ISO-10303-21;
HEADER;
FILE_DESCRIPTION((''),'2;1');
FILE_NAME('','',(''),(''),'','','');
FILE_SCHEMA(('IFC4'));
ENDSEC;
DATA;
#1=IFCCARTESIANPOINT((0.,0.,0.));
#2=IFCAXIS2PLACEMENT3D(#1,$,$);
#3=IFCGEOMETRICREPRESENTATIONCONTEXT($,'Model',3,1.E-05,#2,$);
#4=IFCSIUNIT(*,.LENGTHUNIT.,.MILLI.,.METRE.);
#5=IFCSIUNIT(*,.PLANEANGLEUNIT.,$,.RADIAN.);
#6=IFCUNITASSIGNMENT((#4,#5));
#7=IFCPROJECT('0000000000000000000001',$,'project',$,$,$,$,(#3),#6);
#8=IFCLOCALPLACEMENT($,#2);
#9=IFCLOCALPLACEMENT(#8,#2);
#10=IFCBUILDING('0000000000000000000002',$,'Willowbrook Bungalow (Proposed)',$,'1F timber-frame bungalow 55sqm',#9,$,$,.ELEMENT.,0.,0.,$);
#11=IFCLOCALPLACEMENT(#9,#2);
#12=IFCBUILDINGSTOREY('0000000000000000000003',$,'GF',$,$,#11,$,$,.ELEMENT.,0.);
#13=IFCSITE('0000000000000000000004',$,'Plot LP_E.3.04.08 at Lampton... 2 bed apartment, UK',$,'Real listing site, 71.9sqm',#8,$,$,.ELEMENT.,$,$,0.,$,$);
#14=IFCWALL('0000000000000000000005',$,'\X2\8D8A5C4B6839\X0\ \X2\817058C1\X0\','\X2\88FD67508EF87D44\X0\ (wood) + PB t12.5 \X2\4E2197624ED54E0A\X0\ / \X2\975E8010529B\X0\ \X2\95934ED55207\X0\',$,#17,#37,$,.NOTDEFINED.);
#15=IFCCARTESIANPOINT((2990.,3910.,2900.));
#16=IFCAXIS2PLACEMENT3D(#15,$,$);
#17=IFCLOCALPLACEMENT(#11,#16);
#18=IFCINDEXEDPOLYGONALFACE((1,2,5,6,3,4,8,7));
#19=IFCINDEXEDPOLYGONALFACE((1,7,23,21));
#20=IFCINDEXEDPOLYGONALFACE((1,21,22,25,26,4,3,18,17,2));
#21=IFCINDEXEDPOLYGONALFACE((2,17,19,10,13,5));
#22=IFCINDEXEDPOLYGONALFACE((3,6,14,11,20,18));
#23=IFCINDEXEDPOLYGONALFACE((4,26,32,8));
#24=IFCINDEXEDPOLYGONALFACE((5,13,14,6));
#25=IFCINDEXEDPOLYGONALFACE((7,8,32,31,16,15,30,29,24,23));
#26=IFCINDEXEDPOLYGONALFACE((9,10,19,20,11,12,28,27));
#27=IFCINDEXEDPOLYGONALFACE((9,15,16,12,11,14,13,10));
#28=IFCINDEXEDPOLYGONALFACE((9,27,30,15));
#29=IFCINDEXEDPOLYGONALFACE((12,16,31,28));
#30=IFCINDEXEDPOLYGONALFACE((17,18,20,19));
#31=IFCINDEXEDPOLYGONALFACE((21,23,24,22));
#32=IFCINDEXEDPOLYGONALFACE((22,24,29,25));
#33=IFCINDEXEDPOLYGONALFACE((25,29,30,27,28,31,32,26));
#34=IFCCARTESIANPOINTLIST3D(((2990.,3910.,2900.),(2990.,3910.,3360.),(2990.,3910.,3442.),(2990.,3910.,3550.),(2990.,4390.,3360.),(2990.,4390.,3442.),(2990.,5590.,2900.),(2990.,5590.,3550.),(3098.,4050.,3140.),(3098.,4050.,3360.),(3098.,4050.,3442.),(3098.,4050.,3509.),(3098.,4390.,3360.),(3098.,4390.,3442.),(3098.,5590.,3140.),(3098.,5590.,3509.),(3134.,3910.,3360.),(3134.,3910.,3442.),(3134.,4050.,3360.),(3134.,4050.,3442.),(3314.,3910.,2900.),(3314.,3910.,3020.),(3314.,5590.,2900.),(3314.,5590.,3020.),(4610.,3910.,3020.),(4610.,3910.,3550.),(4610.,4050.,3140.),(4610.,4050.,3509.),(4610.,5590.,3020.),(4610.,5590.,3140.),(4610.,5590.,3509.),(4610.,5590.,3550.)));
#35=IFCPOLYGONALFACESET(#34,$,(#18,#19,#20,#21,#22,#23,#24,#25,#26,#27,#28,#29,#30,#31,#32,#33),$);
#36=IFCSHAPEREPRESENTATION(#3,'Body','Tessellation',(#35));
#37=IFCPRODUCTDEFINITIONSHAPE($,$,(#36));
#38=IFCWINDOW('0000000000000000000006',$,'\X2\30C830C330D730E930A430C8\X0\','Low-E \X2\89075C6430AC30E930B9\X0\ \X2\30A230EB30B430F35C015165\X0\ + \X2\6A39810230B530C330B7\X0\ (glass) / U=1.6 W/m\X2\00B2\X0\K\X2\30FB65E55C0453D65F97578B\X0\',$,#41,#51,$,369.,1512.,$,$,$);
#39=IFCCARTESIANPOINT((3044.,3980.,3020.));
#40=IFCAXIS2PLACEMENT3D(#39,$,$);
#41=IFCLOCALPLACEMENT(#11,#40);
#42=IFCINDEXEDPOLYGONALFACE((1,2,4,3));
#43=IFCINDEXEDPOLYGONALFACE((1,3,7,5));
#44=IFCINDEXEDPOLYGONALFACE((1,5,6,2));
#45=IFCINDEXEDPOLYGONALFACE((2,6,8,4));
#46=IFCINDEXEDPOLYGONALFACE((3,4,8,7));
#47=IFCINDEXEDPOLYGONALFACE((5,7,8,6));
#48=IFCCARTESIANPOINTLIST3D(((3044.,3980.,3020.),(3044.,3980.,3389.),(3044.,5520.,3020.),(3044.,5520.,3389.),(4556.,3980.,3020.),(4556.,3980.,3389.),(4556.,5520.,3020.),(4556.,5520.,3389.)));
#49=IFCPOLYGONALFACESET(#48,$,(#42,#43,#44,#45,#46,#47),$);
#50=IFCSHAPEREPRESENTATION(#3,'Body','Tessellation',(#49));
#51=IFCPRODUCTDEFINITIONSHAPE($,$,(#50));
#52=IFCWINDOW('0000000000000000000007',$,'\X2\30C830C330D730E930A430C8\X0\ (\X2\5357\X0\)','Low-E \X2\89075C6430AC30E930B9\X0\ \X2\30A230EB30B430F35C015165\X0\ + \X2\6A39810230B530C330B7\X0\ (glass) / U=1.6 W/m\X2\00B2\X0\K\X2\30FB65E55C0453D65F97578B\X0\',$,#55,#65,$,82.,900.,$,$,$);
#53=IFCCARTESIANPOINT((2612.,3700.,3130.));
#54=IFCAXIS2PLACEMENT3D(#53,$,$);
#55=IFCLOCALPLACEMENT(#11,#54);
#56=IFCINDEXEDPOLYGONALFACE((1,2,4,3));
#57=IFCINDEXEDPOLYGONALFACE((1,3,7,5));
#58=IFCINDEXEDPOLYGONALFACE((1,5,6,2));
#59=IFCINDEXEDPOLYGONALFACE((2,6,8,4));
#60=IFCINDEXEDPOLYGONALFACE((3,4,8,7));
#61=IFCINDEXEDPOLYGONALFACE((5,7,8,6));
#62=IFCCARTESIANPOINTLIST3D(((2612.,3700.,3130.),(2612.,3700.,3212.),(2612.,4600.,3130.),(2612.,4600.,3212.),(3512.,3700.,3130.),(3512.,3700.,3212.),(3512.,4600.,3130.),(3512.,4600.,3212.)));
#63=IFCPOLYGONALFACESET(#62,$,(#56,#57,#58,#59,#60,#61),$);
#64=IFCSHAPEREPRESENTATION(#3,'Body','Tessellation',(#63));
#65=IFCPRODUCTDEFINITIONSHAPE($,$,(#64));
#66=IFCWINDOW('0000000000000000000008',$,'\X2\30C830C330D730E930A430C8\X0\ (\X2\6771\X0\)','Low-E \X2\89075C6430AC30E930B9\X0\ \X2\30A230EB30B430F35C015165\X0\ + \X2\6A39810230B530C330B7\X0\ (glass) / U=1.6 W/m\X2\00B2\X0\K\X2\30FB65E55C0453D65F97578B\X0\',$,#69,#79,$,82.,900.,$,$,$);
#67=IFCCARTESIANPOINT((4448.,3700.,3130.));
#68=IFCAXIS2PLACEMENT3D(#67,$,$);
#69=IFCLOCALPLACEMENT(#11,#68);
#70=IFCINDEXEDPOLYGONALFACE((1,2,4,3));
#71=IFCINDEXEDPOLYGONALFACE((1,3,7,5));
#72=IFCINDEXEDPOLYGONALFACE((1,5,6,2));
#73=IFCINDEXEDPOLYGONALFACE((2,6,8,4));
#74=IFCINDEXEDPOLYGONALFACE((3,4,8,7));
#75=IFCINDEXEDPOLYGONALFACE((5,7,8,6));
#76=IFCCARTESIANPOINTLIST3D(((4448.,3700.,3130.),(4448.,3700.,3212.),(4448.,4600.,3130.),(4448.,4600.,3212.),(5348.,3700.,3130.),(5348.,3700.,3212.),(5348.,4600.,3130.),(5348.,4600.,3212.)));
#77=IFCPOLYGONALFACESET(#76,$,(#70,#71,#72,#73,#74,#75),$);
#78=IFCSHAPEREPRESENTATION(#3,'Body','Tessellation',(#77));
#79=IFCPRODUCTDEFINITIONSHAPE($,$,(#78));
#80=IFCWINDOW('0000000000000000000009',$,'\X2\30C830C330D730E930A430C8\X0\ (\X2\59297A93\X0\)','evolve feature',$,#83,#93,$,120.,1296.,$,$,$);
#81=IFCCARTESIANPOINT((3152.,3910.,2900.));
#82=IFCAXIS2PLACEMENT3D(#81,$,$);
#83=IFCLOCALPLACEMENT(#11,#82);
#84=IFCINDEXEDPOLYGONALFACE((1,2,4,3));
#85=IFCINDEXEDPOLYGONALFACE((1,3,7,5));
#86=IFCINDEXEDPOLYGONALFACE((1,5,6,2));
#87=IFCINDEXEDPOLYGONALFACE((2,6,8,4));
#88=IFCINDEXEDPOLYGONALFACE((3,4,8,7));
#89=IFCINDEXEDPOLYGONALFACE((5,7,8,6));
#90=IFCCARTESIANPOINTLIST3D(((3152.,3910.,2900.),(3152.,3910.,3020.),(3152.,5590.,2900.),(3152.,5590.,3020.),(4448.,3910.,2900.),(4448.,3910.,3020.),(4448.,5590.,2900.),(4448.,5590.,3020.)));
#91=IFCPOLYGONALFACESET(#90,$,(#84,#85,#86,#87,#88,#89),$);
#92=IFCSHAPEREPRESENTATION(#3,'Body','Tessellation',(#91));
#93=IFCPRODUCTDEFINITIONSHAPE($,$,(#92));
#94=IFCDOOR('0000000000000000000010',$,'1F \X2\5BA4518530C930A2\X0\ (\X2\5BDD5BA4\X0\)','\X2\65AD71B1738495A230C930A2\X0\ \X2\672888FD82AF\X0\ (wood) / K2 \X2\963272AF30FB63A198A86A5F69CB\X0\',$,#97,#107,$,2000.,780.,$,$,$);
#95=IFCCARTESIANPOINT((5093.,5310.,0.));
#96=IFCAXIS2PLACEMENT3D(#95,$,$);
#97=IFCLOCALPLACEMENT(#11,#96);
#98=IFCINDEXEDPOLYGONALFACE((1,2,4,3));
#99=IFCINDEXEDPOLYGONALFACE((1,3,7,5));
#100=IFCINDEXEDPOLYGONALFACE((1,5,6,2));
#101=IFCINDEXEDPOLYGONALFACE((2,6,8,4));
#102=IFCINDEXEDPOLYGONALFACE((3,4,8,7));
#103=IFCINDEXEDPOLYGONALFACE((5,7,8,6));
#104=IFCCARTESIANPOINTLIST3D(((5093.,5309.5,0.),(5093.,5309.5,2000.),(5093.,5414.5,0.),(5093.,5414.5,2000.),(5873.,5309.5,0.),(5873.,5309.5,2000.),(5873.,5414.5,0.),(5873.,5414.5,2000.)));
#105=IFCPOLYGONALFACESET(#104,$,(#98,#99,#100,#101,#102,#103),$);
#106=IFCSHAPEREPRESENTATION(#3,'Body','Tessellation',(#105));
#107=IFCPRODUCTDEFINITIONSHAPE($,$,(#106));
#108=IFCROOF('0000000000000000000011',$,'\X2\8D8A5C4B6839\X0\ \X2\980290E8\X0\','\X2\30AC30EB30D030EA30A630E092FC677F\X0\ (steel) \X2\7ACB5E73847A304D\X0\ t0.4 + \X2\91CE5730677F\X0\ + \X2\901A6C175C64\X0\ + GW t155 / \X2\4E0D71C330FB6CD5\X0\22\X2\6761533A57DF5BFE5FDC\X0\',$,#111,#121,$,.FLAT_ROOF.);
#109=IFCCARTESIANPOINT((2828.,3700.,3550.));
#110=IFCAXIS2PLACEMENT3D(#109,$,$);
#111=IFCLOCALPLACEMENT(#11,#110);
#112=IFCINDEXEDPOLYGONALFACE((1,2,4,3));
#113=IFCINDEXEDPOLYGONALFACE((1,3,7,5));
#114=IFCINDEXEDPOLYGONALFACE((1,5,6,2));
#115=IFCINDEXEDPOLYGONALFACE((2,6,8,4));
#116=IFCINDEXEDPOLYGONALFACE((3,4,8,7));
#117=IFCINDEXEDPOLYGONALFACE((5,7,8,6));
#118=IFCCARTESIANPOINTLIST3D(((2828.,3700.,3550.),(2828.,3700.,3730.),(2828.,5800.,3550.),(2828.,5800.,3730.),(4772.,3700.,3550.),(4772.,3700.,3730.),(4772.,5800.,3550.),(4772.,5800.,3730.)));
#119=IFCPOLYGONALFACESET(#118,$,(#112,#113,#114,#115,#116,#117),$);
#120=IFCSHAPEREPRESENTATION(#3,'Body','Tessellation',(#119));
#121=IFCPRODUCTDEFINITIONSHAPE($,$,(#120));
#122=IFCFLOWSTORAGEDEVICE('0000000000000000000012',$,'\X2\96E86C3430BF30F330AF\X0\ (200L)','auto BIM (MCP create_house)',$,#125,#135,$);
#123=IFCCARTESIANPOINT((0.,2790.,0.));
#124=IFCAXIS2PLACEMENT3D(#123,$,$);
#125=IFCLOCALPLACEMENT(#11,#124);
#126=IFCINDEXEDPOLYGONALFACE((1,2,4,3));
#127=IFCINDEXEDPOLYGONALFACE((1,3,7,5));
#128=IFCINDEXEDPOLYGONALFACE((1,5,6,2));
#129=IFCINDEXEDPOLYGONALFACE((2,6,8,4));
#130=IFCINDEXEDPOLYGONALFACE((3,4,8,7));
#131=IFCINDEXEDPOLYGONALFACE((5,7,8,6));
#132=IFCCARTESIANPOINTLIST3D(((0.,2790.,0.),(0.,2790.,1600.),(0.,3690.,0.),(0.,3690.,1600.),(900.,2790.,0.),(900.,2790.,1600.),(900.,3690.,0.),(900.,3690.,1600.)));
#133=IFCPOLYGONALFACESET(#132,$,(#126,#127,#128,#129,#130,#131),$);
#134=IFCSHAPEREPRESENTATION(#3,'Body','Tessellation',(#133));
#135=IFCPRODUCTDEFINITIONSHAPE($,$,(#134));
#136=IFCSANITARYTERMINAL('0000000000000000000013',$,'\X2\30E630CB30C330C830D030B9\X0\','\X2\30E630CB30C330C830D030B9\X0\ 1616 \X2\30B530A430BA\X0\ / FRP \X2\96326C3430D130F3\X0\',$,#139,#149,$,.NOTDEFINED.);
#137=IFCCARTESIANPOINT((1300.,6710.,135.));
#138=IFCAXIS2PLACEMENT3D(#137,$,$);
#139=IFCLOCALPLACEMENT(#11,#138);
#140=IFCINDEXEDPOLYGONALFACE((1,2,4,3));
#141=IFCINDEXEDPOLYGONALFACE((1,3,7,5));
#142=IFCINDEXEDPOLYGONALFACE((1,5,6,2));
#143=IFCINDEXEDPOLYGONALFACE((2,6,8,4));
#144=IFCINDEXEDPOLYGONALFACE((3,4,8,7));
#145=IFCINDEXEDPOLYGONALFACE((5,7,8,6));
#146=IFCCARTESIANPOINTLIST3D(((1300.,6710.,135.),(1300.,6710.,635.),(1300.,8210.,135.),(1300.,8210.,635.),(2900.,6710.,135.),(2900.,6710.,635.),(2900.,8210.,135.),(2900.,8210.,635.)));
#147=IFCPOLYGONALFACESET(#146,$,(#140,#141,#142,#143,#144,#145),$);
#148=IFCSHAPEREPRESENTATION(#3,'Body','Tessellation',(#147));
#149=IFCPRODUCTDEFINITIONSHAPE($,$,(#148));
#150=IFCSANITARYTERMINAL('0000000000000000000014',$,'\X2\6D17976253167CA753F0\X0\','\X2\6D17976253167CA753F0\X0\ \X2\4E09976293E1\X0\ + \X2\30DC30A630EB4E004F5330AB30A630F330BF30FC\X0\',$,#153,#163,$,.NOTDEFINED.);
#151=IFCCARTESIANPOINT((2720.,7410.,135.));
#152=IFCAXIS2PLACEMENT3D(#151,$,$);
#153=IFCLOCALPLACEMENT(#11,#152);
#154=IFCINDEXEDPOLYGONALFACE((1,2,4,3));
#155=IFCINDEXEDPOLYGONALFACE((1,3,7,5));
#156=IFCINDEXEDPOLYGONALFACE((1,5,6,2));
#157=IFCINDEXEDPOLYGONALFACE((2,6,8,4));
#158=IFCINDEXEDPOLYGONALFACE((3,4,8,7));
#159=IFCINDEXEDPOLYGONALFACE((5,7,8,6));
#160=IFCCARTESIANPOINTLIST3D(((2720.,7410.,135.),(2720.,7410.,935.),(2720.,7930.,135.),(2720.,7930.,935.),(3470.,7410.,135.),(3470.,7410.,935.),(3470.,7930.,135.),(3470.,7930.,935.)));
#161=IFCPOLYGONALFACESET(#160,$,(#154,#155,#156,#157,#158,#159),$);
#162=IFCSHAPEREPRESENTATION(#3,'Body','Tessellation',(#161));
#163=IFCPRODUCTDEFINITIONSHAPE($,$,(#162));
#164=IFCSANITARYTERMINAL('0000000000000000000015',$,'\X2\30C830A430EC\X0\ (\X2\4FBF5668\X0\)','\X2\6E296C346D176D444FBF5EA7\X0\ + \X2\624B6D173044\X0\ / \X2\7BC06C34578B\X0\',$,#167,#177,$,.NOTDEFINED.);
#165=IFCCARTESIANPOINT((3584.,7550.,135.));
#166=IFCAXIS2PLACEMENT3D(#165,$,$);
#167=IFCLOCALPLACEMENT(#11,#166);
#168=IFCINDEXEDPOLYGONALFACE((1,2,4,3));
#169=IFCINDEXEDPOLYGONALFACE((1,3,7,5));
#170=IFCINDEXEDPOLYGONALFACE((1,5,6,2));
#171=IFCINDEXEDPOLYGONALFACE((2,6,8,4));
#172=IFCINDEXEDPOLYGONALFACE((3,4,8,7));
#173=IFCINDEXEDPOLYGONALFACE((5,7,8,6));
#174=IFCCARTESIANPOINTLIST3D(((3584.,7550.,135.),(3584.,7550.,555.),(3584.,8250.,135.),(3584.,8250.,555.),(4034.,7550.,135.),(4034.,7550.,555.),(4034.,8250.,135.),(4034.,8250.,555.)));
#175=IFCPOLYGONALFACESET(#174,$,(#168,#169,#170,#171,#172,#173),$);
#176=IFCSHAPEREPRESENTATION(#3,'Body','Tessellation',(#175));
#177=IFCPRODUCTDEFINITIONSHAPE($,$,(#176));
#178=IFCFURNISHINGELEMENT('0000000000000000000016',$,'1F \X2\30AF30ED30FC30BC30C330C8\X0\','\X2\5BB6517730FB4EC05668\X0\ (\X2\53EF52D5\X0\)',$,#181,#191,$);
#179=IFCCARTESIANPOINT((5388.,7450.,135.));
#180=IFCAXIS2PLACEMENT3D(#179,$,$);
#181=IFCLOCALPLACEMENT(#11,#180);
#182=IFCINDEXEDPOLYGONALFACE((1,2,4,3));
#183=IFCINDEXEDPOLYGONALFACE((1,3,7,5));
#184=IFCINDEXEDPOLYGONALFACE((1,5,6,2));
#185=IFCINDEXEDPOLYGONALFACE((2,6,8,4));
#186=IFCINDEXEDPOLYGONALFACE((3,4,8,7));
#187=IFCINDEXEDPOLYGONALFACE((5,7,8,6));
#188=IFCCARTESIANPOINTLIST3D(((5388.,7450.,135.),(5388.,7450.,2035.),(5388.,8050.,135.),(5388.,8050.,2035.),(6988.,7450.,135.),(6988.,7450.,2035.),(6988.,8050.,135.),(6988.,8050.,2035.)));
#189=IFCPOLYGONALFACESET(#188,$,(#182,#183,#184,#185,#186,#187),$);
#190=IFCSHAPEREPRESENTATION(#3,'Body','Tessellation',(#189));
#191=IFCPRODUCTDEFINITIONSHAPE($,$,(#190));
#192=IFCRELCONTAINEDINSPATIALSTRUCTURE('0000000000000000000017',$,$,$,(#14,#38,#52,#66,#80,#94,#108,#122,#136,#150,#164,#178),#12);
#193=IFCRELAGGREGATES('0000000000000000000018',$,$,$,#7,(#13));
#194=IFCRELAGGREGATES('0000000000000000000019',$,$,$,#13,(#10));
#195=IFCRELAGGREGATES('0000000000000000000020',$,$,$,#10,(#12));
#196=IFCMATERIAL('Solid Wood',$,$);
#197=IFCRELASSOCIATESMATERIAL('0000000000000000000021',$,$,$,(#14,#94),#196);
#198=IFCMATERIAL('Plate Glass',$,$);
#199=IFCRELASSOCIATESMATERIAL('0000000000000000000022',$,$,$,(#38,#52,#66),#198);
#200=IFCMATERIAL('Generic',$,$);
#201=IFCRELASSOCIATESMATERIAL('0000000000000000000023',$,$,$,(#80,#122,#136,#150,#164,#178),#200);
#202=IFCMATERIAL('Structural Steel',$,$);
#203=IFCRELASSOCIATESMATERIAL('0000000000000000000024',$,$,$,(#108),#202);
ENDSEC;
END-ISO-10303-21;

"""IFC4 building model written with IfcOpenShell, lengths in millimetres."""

from ifc_helpers import new_model, si_unit, frame, frame_2d, origin, place, context, project, spatial, rectangle, extrude, material, element, fill, save


model = new_model("IFC4")

# Units and contexts
model_context = context("Model", 3, precision=1e-05, world=origin())
ifc_project = project(units=[si_unit("LENGTHUNIT", "METRE", prefix="MILLI"), si_unit("PLANEANGLEUNIT", "RADIAN")], contexts=[model_context])

# Site, building, storey
site_placement = place(None, origin())
site = spatial("IfcSite", under=ifc_project, at=site_placement, Name="Plot LP_E.3.04.08 at Lampton... 2 bed apartment, UK", ObjectType="Real listing site, 71.9sqm", CompositionType="ELEMENT", RefElevation=0.0)
building_placement = place(site_placement, origin())
building = spatial("IfcBuilding", under=site, at=building_placement, Name="Willowbrook Bungalow (Proposed)", ObjectType="1F timber-frame bungalow 55sqm", CompositionType="ELEMENT", ElevationOfRefHeight=0.0, ElevationOfTerrain=0.0)
storey_placement = place(building_placement, origin())
storey = spatial("IfcBuildingStorey", under=building, at=storey_placement, Name="GF", CompositionType="ELEMENT", Elevation=0.0)

# Shared definitions
ifc_material_1 = material(Name="Solid Wood")

# Shared definitions
ifc_material_2 = material(Name="Plate Glass")

# Wall, openings, windows
wall_1_placement = place(storey_placement, frame((2990.0, 3910.0, 2900.0)))
wall_1 = element("IfcWall", 1, at=wall_1_placement, inside=storey, material=ifc_material_1, Name="越屋根 腰壁", Description="製材軸組 (wood) + PB t12.5 両面仕上 / 非耐力 間仕切", PredefinedType="NOTDEFINED", context=model_context, shape_type="SweptSolid", body=[
    extrude(rectangle(XDim=1620.0, YDim=1680.0, at=frame_2d((810.0, 840.0))), frame((2990.0, 3910.0, 2900.0)), (0.0, 0.0, 1.0), 650.0),
])
opening_1_placement = place(storey_placement, frame((3044.0, 3980.0, 3020.0)))
opening_1 = element("IfcOpeningElement", 2, at=opening_1_placement, cuts=wall_1, PredefinedType="NOTDEFINED", context=model_context, shape_type="SweptSolid", body=[
    extrude(rectangle(XDim=1512.0, YDim=1540.0, at=frame_2d((756.0, 770.0))), frame((3044.0, 3980.0, 3020.0)), (0.0, 0.0, 1.0), 369.0),
])
opening_2_placement = place(storey_placement, frame((2612.0, 3700.0, 3130.0)))
opening_2 = element("IfcOpeningElement", 3, at=opening_2_placement, cuts=wall_1, PredefinedType="NOTDEFINED", context=model_context, shape_type="SweptSolid", body=[
    extrude(rectangle(XDim=900.0, YDim=900.0, at=frame_2d((450.0, 450.0))), frame((2612.0, 3700.0, 3130.0)), (0.0, 0.0, 1.0), 82.0),
])
opening_3_placement = place(storey_placement, frame((4448.0, 3700.0, 3130.0)))
opening_3 = element("IfcOpeningElement", 4, at=opening_3_placement, cuts=wall_1, PredefinedType="NOTDEFINED", context=model_context, shape_type="SweptSolid", body=[
    extrude(rectangle(XDim=900.0, YDim=900.0, at=frame_2d((450.0, 450.0))), frame((4448.0, 3700.0, 3130.0)), (0.0, 0.0, 1.0), 82.0),
])
opening_4_placement = place(storey_placement, frame((3152.0, 3910.0, 2900.0)))
opening_4 = element("IfcOpeningElement", 5, at=opening_4_placement, cuts=wall_1, PredefinedType="NOTDEFINED", context=model_context, shape_type="SweptSolid", body=[
    extrude(rectangle(XDim=1296.0, YDim=1680.0, at=frame_2d((648.0, 840.0))), frame((3152.0, 3910.0, 2900.0)), (0.0, 0.0, 1.0), 120.0),
])
window_1_placement = place(storey_placement, frame((3044.0, 3980.0, 3020.0)))
window_1 = element("IfcWindow", 6, at=window_1_placement, inside=storey, material=ifc_material_2, Name="トップライト", Description="Low-E 複層ガラス アルゴン封入 + 樹脂サッシ (glass) / U=1.6 W/m²K・日射取得型", OverallHeight=369.0, OverallWidth=1512.0, context=model_context, shape_type="SweptSolid", body=[
    extrude(rectangle(XDim=1512.0, YDim=1540.0, at=frame_2d((756.0, 770.0))), frame((3044.0, 3980.0, 3020.0)), (0.0, 0.0, 1.0), 369.0),
])
fill(opening_1, window_1)
window_2_placement = place(storey_placement, frame((2612.0, 3700.0, 3130.0)))
window_2 = element("IfcWindow", 7, at=window_2_placement, inside=storey, material=ifc_material_2, Name="トップライト (南)", Description="Low-E 複層ガラス アルゴン封入 + 樹脂サッシ (glass) / U=1.6 W/m²K・日射取得型", OverallHeight=82.0, OverallWidth=900.0, context=model_context, shape_type="SweptSolid", body=[
    extrude(rectangle(XDim=900.0, YDim=900.0, at=frame_2d((450.0, 450.0))), frame((2612.0, 3700.0, 3130.0)), (0.0, 0.0, 1.0), 82.0),
])
fill(opening_2, window_2)
window_3_placement = place(storey_placement, frame((4448.0, 3700.0, 3130.0)))
window_3 = element("IfcWindow", 8, at=window_3_placement, inside=storey, material=ifc_material_2, Name="トップライト (東)", Description="Low-E 複層ガラス アルゴン封入 + 樹脂サッシ (glass) / U=1.6 W/m²K・日射取得型", OverallHeight=82.0, OverallWidth=900.0, context=model_context, shape_type="SweptSolid", body=[
    extrude(rectangle(XDim=900.0, YDim=900.0, at=frame_2d((450.0, 450.0))), frame((4448.0, 3700.0, 3130.0)), (0.0, 0.0, 1.0), 82.0),
])
fill(opening_3, window_3)
ifc_material_3 = material(Name="Generic")
window_4_placement = place(storey_placement, frame((3152.0, 3910.0, 2900.0)))
window_4 = element("IfcWindow", 9, at=window_4_placement, inside=storey, material=ifc_material_3, Name="トップライト (天窓)", Description="evolve feature", OverallHeight=120.0, OverallWidth=1296.0, context=model_context, shape_type="SweptSolid", body=[
    extrude(rectangle(XDim=1296.0, YDim=1680.0, at=frame_2d((648.0, 840.0))), frame((3152.0, 3910.0, 2900.0)), (0.0, 0.0, 1.0), 120.0),
])
fill(opening_4, window_4)

# Door
door_1_placement = place(storey_placement, frame((5093.0, 5310.0, 0.0)))
element("IfcDoor", 10, at=door_1_placement, inside=storey, material=ifc_material_1, Name="1F 室内ドア (寝室)", Description="断熱玄関ドア 木製芯 (wood) / K2 防犯・採風機構", OverallHeight=2000.0, OverallWidth=780.0, context=model_context, shape_type="SweptSolid", body=[
    extrude(rectangle(XDim=780.0, YDim=105.0, at=frame_2d((390.0, 52.0))), frame((5093.0, 5310.0, 0.0)), (0.0, 0.0, 1.0), 2000.0),
])

# Roof
ifc_material_4 = material(Name="Structural Steel")
roof_placement = place(storey_placement, frame((2828.0, 3700.0, 3550.0)))
element("IfcRoof", 11, at=roof_placement, inside=storey, material=ifc_material_4, Name="越屋根 頂部", Description="ガルバリウム鋼板 (steel) 立平葺き t0.4 + 野地板 + 通気層 + GW t155 / 不燃・法22条区域対応", PredefinedType="FLAT_ROOF", context=model_context, shape_type="SweptSolid", body=[
    extrude(rectangle(XDim=1944.0, YDim=2100.0, at=frame_2d((972.0, 1050.0))), frame((2828.0, 3700.0, 3550.0)), (0.0, 0.0, 1.0), 180.0),
])

# Flow storage device
flow_storage_device_placement = place(storey_placement, frame((0.0, 2790.0, 0.0)))
element("IfcFlowStorageDevice", 12, at=flow_storage_device_placement, inside=storey, material=ifc_material_3, Name="雨水タンク (200L)", Description="auto BIM (MCP create_house)", context=model_context, shape_type="SweptSolid", body=[
    extrude(rectangle(XDim=900.0, YDim=900.0, at=frame_2d((450.0, 450.0))), frame((0.0, 2790.0, 0.0)), (0.0, 0.0, 1.0), 1600.0),
])

# Sanitary terminals
sanitary_terminal_1_placement = place(storey_placement, frame((1300.0, 6710.0, 135.0)))
element("IfcSanitaryTerminal", 13, at=sanitary_terminal_1_placement, inside=storey, material=ifc_material_3, Name="ユニットバス", Description="ユニットバス 1616 サイズ / FRP 防水パン", PredefinedType="NOTDEFINED", context=model_context, shape_type="SweptSolid", body=[
    extrude(rectangle(XDim=1600.0, YDim=1500.0, at=frame_2d((800.0, 750.0))), frame((1300.0, 6710.0, 135.0)), (0.0, 0.0, 1.0), 500.0),
])
sanitary_terminal_2_placement = place(storey_placement, frame((2720.0, 7410.0, 135.0)))
element("IfcSanitaryTerminal", 14, at=sanitary_terminal_2_placement, inside=storey, material=ifc_material_3, Name="洗面化粧台", Description="洗面化粧台 三面鏡 + ボウル一体カウンター", PredefinedType="NOTDEFINED", context=model_context, shape_type="SweptSolid", body=[
    extrude(rectangle(XDim=750.0, YDim=520.0, at=frame_2d((375.0, 260.0))), frame((2720.0, 7410.0, 135.0)), (0.0, 0.0, 1.0), 800.0),
])
sanitary_terminal_3_placement = place(storey_placement, frame((3584.0, 7550.0, 135.0)))
element("IfcSanitaryTerminal", 15, at=sanitary_terminal_3_placement, inside=storey, material=ifc_material_3, Name="トイレ (便器)", Description="温水洗浄便座 + 手洗い / 節水型", PredefinedType="NOTDEFINED", context=model_context, shape_type="SweptSolid", body=[
    extrude(rectangle(XDim=450.0, YDim=700.0, at=frame_2d((225.0, 350.0))), frame((3584.0, 7550.0, 135.0)), (0.0, 0.0, 1.0), 420.0),
])

# Furnishing element
furnishing_1_placement = place(storey_placement, frame((5388.0, 7450.0, 135.0)))
element("IfcFurnishingElement", 16, at=furnishing_1_placement, inside=storey, material=ifc_material_3, Name="1F クローゼット", Description="家具・什器 (可動)", context=model_context, shape_type="SweptSolid", body=[
    extrude(rectangle(XDim=1600.0, YDim=600.0, at=frame_2d((800.0, 300.0))), frame((5388.0, 7450.0, 135.0)), (0.0, 0.0, 1.0), 1900.0),
])

save(model, "model.ifc")
